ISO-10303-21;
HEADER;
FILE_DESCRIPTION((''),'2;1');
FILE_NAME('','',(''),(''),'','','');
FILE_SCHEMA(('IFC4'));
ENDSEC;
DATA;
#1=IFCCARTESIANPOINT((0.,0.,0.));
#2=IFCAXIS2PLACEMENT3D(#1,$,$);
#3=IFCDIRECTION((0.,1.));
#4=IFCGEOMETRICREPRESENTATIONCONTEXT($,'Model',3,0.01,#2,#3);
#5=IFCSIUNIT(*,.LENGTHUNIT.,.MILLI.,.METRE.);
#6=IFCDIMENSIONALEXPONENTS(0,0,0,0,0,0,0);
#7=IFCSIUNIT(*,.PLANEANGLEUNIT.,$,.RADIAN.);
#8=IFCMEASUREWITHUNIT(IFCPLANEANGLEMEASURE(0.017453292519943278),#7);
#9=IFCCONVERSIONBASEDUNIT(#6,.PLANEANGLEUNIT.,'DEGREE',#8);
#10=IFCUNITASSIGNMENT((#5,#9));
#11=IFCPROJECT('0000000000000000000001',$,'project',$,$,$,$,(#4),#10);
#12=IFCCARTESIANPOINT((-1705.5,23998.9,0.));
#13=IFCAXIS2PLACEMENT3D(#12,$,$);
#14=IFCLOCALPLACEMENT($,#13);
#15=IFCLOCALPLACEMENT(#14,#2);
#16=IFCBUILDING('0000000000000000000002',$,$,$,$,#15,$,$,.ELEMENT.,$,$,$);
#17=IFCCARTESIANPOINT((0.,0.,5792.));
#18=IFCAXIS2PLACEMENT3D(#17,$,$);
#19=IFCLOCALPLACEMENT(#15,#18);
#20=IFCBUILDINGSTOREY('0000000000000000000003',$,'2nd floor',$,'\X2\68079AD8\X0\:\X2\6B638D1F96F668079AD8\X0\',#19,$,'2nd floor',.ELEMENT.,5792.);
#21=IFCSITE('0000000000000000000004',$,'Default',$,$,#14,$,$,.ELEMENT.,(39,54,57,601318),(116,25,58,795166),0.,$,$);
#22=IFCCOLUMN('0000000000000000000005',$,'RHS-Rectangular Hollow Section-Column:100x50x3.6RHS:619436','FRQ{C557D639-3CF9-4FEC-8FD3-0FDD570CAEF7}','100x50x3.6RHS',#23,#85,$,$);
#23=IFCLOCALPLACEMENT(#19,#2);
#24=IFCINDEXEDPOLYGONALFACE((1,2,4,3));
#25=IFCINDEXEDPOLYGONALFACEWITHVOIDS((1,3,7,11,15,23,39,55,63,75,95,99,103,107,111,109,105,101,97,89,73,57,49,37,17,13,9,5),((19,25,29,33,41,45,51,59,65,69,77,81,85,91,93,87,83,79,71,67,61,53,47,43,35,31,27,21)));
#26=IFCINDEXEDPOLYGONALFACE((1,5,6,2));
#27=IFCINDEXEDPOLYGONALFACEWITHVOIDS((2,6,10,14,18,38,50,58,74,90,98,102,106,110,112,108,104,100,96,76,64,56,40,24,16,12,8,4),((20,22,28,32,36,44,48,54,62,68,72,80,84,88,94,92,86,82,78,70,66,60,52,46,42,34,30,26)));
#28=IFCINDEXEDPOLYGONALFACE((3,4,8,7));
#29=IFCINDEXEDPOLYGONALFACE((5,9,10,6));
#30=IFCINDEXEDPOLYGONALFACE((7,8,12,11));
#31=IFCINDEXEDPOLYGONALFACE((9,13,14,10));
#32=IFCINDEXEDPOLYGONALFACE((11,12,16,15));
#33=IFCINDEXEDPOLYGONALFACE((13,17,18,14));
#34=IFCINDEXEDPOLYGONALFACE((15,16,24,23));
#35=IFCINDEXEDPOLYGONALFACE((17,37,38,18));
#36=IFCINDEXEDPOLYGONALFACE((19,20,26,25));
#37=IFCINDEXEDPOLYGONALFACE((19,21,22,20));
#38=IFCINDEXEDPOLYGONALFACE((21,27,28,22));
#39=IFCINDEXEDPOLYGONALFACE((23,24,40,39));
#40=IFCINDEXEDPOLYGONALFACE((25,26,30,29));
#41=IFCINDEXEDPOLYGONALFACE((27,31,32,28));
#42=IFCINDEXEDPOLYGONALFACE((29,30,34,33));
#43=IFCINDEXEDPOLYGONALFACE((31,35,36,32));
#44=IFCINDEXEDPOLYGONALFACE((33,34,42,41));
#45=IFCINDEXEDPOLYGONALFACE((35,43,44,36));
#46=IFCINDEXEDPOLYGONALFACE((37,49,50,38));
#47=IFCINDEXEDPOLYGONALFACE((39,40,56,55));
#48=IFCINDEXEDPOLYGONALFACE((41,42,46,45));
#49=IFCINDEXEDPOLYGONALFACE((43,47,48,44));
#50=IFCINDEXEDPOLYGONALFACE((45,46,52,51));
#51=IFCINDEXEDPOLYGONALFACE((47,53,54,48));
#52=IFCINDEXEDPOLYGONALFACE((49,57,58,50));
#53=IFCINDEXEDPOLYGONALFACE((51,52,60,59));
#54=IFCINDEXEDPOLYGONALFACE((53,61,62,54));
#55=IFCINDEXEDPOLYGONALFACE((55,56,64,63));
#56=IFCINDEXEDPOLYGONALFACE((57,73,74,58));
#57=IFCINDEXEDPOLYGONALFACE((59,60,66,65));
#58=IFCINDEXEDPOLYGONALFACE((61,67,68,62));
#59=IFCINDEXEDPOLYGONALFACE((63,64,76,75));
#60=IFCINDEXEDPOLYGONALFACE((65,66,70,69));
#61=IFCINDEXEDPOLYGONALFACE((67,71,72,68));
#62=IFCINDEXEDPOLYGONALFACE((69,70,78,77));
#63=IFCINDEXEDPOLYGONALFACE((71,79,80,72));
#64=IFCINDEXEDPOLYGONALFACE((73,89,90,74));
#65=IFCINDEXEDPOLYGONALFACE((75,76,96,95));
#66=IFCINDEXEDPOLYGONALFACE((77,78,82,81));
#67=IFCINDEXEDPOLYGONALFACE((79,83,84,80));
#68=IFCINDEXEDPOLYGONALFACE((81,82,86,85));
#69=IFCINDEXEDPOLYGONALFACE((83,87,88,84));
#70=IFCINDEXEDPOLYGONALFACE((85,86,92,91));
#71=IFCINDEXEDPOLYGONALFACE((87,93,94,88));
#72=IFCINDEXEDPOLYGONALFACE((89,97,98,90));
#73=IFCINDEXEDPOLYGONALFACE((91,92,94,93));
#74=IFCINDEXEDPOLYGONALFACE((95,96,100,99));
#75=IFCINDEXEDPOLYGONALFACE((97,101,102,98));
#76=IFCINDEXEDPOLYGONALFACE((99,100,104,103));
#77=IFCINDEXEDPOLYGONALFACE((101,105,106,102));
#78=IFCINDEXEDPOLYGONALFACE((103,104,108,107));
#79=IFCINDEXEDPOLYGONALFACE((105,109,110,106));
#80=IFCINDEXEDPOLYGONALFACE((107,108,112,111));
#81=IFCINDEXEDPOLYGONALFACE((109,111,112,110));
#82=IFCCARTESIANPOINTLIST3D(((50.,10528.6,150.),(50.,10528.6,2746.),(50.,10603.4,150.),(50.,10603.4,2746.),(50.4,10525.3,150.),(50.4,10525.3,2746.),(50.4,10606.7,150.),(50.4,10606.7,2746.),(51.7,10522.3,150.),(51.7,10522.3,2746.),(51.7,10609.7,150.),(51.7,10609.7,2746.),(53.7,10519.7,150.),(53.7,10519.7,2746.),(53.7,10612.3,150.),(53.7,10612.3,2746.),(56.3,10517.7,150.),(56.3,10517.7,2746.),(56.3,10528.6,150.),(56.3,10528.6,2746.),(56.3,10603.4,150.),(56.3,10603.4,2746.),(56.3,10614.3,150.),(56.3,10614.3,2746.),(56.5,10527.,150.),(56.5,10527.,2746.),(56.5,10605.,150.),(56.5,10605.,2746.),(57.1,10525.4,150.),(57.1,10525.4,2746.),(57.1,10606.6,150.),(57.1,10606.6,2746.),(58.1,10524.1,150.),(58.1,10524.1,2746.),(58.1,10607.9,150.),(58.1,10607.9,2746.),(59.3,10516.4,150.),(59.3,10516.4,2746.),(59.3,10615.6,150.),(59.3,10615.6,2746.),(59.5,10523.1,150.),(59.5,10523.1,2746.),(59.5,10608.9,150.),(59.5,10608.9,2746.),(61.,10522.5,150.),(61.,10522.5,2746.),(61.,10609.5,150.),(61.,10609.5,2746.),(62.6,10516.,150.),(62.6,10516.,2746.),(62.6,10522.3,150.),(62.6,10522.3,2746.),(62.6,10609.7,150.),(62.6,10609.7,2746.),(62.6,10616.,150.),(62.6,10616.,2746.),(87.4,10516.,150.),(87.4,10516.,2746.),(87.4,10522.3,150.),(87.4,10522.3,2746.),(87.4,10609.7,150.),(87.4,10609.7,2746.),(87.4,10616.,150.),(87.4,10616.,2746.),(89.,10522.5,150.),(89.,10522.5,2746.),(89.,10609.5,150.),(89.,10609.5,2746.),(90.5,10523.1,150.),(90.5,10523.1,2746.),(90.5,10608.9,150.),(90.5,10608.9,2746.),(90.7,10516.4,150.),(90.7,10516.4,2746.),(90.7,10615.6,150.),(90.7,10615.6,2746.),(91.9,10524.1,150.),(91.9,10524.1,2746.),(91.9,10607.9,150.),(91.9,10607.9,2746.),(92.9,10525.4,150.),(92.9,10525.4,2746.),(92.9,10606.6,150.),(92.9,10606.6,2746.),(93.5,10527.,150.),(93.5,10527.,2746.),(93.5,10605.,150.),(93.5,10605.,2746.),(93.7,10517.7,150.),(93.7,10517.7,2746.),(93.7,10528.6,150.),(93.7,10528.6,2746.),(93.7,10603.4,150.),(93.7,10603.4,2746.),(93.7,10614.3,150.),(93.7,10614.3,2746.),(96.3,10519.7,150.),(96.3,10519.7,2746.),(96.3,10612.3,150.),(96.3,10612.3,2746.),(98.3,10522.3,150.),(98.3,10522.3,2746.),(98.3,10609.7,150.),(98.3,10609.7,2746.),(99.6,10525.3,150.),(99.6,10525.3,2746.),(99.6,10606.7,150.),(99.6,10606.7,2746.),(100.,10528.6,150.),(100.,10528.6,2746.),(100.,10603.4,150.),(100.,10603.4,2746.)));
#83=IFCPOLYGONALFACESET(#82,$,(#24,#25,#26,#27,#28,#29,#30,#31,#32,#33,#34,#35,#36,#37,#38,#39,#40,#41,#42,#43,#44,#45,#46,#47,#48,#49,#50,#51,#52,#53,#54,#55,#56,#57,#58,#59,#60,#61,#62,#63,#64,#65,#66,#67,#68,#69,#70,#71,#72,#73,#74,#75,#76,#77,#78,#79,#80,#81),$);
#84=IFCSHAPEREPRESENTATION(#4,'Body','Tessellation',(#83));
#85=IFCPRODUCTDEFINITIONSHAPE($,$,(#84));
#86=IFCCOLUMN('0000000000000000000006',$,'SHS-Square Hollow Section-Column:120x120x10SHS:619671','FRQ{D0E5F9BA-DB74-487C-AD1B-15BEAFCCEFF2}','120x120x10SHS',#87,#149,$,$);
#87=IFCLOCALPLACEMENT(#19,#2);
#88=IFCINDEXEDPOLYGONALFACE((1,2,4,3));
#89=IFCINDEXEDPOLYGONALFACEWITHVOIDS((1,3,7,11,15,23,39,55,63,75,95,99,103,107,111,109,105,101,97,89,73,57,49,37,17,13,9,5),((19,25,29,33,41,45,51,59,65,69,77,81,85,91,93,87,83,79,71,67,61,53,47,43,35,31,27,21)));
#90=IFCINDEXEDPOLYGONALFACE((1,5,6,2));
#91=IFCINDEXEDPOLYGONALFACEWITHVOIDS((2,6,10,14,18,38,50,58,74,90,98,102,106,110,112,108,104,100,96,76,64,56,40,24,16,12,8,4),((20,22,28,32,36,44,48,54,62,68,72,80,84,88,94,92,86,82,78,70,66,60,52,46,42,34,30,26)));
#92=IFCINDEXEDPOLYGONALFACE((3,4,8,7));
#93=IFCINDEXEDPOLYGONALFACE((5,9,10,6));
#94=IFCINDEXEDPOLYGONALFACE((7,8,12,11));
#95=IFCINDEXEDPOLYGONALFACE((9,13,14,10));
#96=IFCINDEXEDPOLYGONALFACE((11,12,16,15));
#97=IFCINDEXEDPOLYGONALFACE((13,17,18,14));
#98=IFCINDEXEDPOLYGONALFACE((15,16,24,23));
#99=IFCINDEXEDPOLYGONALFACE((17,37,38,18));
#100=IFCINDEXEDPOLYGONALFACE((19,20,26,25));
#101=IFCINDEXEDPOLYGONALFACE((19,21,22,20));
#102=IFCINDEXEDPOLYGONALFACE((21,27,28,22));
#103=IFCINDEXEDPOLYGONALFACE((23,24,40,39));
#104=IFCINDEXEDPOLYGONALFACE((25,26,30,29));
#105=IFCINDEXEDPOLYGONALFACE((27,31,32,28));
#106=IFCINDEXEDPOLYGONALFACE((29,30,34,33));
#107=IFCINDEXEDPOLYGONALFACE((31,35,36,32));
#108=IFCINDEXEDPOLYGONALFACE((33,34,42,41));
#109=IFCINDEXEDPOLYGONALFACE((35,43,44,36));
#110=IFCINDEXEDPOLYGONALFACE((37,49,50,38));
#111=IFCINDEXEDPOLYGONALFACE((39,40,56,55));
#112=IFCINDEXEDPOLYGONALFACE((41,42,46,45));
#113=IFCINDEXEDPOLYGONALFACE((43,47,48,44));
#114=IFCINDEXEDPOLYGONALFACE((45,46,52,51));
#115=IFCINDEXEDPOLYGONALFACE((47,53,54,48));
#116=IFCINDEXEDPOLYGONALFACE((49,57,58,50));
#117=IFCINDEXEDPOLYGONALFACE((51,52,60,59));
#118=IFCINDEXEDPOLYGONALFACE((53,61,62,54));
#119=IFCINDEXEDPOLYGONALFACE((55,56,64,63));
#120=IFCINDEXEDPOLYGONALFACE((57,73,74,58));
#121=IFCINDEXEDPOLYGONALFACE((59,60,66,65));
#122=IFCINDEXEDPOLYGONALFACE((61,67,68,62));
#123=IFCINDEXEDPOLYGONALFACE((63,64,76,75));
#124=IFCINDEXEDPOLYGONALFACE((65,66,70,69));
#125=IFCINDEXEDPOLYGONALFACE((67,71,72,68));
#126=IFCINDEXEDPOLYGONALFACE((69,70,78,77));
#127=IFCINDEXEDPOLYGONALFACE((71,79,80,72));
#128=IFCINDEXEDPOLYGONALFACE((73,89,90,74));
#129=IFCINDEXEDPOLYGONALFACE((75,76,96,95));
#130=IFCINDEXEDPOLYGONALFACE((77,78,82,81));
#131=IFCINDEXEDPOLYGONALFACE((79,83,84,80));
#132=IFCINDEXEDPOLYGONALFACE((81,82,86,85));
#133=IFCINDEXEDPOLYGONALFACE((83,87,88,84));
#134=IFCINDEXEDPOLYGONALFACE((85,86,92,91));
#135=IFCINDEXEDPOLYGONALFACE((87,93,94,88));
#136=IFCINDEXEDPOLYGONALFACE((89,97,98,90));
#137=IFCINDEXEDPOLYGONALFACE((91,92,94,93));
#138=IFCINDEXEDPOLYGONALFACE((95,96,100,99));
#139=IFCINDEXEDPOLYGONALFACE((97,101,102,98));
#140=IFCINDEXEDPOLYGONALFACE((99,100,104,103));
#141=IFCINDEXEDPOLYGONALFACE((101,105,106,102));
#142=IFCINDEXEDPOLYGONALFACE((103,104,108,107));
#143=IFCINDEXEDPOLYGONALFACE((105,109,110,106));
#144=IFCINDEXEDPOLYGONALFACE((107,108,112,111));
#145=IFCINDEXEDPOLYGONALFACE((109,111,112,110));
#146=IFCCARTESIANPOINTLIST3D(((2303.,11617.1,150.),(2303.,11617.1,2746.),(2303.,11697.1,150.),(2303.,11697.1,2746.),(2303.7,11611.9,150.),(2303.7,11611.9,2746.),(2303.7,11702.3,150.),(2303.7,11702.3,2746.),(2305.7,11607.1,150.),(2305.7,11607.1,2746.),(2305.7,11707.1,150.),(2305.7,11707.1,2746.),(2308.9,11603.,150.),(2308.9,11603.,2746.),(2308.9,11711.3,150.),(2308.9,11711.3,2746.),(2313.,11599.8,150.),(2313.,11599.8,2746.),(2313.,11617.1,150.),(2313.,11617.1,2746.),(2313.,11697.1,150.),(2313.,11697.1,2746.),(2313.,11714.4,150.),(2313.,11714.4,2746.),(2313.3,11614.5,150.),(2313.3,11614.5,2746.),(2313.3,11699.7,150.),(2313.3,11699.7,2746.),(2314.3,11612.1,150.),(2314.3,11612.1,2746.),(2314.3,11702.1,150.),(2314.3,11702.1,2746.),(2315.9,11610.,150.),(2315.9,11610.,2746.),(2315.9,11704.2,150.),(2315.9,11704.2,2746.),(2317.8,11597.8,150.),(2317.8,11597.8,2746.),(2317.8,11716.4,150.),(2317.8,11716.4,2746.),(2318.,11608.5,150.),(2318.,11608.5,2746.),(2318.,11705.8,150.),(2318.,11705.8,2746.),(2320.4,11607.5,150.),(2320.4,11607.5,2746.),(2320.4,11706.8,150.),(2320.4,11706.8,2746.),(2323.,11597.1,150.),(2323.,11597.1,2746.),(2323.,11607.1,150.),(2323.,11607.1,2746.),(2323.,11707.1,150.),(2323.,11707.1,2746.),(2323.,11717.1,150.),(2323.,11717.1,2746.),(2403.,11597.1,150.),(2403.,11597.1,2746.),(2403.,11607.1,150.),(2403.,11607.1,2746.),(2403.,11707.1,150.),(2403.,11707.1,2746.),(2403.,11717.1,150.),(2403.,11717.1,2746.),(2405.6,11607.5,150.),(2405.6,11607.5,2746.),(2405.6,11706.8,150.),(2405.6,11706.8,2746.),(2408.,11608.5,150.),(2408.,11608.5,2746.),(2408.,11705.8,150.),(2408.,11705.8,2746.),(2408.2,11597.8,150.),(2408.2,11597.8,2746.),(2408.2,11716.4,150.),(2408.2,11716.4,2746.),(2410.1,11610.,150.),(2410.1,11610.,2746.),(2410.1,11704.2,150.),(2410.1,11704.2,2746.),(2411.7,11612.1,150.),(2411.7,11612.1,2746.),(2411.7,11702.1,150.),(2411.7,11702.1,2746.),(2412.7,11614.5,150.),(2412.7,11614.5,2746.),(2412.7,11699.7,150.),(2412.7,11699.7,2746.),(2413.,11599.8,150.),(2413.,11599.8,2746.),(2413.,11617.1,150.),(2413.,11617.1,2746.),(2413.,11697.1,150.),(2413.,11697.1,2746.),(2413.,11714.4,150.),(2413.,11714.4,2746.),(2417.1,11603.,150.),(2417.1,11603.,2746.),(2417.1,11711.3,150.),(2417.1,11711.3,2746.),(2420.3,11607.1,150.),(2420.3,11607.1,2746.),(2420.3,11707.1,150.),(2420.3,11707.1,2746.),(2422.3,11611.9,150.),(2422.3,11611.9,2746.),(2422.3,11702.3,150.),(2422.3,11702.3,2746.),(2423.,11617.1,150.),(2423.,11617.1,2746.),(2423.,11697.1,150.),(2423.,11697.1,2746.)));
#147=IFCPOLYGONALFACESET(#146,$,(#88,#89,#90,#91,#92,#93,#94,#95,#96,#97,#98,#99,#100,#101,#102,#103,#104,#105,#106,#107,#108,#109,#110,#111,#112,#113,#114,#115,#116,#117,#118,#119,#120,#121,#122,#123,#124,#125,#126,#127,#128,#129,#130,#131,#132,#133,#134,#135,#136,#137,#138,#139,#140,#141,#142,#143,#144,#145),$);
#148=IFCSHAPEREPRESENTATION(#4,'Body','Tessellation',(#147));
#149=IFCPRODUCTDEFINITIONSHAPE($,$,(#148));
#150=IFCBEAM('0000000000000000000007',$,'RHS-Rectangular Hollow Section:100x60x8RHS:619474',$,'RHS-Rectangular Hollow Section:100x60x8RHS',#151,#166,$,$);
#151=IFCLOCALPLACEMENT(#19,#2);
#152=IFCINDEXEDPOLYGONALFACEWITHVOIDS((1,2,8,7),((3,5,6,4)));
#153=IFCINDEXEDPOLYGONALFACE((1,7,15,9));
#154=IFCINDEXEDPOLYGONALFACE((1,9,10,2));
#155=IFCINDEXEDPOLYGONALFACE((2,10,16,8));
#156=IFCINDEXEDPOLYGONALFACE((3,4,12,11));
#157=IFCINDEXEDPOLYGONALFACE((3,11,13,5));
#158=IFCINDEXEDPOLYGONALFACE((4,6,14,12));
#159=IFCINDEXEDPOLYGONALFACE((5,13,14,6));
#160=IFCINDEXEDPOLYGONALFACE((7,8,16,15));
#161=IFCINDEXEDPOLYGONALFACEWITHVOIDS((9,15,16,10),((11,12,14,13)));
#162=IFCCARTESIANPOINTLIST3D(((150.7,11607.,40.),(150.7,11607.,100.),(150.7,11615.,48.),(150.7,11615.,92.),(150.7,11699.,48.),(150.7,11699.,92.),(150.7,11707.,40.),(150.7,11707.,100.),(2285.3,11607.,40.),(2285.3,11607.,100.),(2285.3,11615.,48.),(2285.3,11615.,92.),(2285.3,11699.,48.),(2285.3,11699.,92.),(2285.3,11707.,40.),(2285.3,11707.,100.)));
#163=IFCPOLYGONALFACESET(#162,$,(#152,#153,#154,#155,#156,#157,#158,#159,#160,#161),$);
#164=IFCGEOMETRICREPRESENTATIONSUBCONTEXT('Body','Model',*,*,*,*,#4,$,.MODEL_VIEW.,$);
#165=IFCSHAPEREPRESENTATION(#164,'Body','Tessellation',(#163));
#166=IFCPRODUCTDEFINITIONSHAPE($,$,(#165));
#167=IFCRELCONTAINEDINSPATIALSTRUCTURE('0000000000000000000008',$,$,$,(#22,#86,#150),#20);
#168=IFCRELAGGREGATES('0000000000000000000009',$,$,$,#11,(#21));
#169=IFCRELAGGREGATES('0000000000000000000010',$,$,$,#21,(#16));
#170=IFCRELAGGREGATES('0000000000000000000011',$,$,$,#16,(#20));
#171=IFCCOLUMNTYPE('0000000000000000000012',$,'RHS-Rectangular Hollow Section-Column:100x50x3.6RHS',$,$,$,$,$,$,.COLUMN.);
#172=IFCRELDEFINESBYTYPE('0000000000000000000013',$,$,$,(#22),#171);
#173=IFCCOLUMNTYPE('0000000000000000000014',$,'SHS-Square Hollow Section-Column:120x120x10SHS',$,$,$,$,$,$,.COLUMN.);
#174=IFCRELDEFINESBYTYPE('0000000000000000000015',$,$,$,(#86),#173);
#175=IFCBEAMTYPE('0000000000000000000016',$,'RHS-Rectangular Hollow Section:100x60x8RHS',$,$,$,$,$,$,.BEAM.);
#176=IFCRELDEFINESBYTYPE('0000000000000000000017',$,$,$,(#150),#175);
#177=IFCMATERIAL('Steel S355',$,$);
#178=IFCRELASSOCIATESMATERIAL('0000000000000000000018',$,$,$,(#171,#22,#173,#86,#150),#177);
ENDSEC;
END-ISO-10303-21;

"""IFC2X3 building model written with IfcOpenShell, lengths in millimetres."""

from ifc_helpers import new_model, entity, si_unit, converted_unit, point, direction, frame, frame_2d, origin, origin_2d, place, context, subcontext, project, spatial, circle_curve, line_curve, trimmed, segment, composite_curve, rectangle, hollow_rectangle, outline, extrude, boolean, clip, halfspace, material, type_object, element, save


model = new_model("IFC2X3")

# Units and contexts
model_context = context("Model", 3, precision=0.01, world=origin(), true_north=direction((0.0, 1.0)))
body_context = subcontext(model_context, "Body", "Model", "MODEL_VIEW")
ifc_project = project(units=[si_unit("LENGTHUNIT", "METRE", prefix="MILLI"), converted_unit("PLANEANGLEUNIT", "DEGREE", entity("IfcPlaneAngleMeasure", 0.017453292519943278), si_unit("PLANEANGLEUNIT", "RADIAN"), dimensions=[0, 0, 0, 0, 0, 0, 0])], contexts=[model_context])

# Site, building, storey
site_placement = place(None, frame((-1705.5, 23998.9, 0.0)))
site = spatial("IfcSite", under=ifc_project, at=site_placement, Name="Default", CompositionType="ELEMENT", RefLatitude=(39, 54, 57, 601318), RefLongitude=(116, 25, 58, 795166), RefElevation=0.0)
building_placement = place(site_placement, origin())
building = spatial("IfcBuilding", under=site, at=building_placement, CompositionType="ELEMENT")
storey_placement = place(building_placement, frame((0.0, 0.0, 5792.0)))
storey = spatial("IfcBuildingStorey", under=building, at=storey_placement, Name="2nd floor", ObjectType="标高:正负零标高", LongName="2nd floor", CompositionType="ELEMENT", Elevation=5792.0)

# Shared definitions
ifc_material_1 = material(Name="Steel S355")

# Column, opening
column_type_1 = type_object("IfcColumnType", Name="RHS-Rectangular Hollow Section-Column:100x50x3.6RHS", PredefinedType="COLUMN", material=ifc_material_1)
column_1_placement = place(storey_placement, frame((75.0, 10566.0, 2876.9)))
column_1 = element("IfcColumn", 1, at=column_1_placement, inside=storey, type_object=column_type_1, material=ifc_material_1, Name="RHS-Rectangular Hollow Section-Column:100x50x3.6RHS:619436", Description="FRQ{C557D639-3CF9-4FEC-8FD3-0FDD570CAEF7}", ObjectType="100x50x3.6RHS", context=model_context, shape_type="Clipping", body=[
    clip(clip(extrude(hollow_rectangle(XDim=50.0, YDim=100.0, WallThickness=6.3, InnerFilletRadius=6.3, OuterFilletRadius=12.6, at=origin_2d()), origin(), (0.0, 0.0, -1.0), 2782.8), halfspace(frame((-75.0, -10566.0, -2726.9), z_axis=(0.0, 0.0, 1.0), x_axis=(1.0, 0.0, 0.0)), True)), halfspace(frame((-75.0, -10566.0, -55.9), z_axis=(0.0, 0.0, -1.0), x_axis=(-1.0, 0.0, 0.0)), True)),
])
opening_1_placement = place(column_1_placement, frame((0.0, -150.1, -130.9), z_axis=(0.0, 1.0, 0.0), x_axis=(-1.0, 0.0, 0.0)))
element("IfcOpeningElement", 2, at=opening_1_placement, cuts=column_1, ObjectType="Opening", context=model_context, shape_type="SweptSolid", body=[
    extrude(outline(composite_curve([segment(trimmed(circle_curve(frame_2d((43.0, 32.0), x_axis=(1.0, 0.0)), 32.0), [point((43.0, 0.0))], [point((75.0, 32.0))], True, "CARTESIAN"), True, "CONTINUOUS"), segment(trimmed(line_curve((75.0, 32.0), (0.0, 1.0), 86.0), [point((75.0, 32.0))], [point((75.0, 118.0))], True, "CARTESIAN"), True, "CONTINUOUS"), segment(trimmed(circle_curve(frame_2d((43.0, 118.0), x_axis=(1.0, 0.0)), 32.0), [point((75.0, 118.0))], [point((43.0, 150.0))], True, "CARTESIAN"), True, "CONTINUOUS"), segment(trimmed(line_curve((43.0, 150.0), (-1.0, 0.0), 86.0), [point((43.0, 150.0))], [point((-43.0, 150.0))], True, "CARTESIAN"), True, "CONTINUOUS"), segment(trimmed(circle_curve(frame_2d((-43.0, 118.0), x_axis=(1.0, 0.0)), 32.0), [point((-43.0, 150.0))], [point((-75.0, 118.0))], True, "CARTESIAN"), True, "CONTINUOUS"), segment(trimmed(line_curve((-75.0, 118.0), (0.0, -1.0), 86.0), [point((-75.0, 118.0))], [point((-75.0, 32.0))], True, "CARTESIAN"), True, "CONTINUOUS"), segment(trimmed(circle_curve(frame_2d((-43.0, 32.0), x_axis=(1.0, 0.0)), 32.0), [point((-75.0, 32.0))], [point((-43.0, 0.0))], True, "CARTESIAN"), True, "CONTINUOUS"), segment(trimmed(line_curve((-43.0, 0.0), (1.0, 0.0), 86.0), [point((-43.0, 0.0))], [point((43.0, 0.0))], True, "CARTESIAN"), True, "CONTINUOUS")], self_intersect="UNKNOWN")), origin(), (0.0, 0.0, 1.0), 300.2),
])

# Column
column_type_2 = type_object("IfcColumnType", Name="SHS-Square Hollow Section-Column:120x120x10SHS", PredefinedType="COLUMN", material=ifc_material_1)
column_2_placement = place(storey_placement, frame((2363.0, 11657.1, 2746.0), z_axis=(0.0, 0.0, 1.0), x_axis=(0.0, 1.0, 0.0)))
element("IfcColumn", 3, at=column_2_placement, inside=storey, type_object=column_type_2, material=ifc_material_1, Name="SHS-Square Hollow Section-Column:120x120x10SHS:619671", Description="FRQ{D0E5F9BA-DB74-487C-AD1B-15BEAFCCEFF2}", ObjectType="120x120x10SHS", context=model_context, shape_type="Clipping", body=[
    clip(extrude(hollow_rectangle(XDim=120.0, YDim=120.0, WallThickness=10.0, InnerFilletRadius=10.0, OuterFilletRadius=20.0, at=origin_2d()), origin(), (0.0, 0.0, -1.0), 2680.9), halfspace(frame((-11657.1, 2363.0, -2596.0), z_axis=(0.0, 0.0, 1.0), x_axis=(0.0, -1.0, 0.0)), True)),
])

# Beam
beam_type_1 = type_object("IfcBeamType", Name="RHS-Rectangular Hollow Section:100x60x8RHS", PredefinedType="BEAM")
beam_1_placement = place(storey_placement, frame((150.7, 11707.0, 70.0)))
element("IfcBeam", 4, at=beam_1_placement, inside=storey, type_object=beam_type_1, material=ifc_material_1, Name="RHS-Rectangular Hollow Section:100x60x8RHS:619474", ObjectType="RHS-Rectangular Hollow Section:100x60x8RHS", context=body_context, shape_type="SweptSolid", body=[
    boolean("DIFFERENCE", extrude(rectangle(XDim=60.0, YDim=100.0, at=frame_2d((0.0, 0.0), x_axis=(1.0, 0.0))), frame((0.0, -50.0, 0.0), z_axis=(1.0, 0.0, 0.0), x_axis=(0.0, 0.0, -1.0)), (0.0, 0.0, 1.0), 2134.6), extrude(rectangle(XDim=44.0, YDim=84.0, at=frame_2d((0.0, 0.0), x_axis=(0.0, 1.0))), frame((2134.6, -50.0, 0.0), z_axis=(-1.0, 0.0, 0.0), x_axis=(0.0, 1.0, 0.0)), (0.0, 0.0, 1.0), 2134.6)),
])

save(model, "model.ifc")
